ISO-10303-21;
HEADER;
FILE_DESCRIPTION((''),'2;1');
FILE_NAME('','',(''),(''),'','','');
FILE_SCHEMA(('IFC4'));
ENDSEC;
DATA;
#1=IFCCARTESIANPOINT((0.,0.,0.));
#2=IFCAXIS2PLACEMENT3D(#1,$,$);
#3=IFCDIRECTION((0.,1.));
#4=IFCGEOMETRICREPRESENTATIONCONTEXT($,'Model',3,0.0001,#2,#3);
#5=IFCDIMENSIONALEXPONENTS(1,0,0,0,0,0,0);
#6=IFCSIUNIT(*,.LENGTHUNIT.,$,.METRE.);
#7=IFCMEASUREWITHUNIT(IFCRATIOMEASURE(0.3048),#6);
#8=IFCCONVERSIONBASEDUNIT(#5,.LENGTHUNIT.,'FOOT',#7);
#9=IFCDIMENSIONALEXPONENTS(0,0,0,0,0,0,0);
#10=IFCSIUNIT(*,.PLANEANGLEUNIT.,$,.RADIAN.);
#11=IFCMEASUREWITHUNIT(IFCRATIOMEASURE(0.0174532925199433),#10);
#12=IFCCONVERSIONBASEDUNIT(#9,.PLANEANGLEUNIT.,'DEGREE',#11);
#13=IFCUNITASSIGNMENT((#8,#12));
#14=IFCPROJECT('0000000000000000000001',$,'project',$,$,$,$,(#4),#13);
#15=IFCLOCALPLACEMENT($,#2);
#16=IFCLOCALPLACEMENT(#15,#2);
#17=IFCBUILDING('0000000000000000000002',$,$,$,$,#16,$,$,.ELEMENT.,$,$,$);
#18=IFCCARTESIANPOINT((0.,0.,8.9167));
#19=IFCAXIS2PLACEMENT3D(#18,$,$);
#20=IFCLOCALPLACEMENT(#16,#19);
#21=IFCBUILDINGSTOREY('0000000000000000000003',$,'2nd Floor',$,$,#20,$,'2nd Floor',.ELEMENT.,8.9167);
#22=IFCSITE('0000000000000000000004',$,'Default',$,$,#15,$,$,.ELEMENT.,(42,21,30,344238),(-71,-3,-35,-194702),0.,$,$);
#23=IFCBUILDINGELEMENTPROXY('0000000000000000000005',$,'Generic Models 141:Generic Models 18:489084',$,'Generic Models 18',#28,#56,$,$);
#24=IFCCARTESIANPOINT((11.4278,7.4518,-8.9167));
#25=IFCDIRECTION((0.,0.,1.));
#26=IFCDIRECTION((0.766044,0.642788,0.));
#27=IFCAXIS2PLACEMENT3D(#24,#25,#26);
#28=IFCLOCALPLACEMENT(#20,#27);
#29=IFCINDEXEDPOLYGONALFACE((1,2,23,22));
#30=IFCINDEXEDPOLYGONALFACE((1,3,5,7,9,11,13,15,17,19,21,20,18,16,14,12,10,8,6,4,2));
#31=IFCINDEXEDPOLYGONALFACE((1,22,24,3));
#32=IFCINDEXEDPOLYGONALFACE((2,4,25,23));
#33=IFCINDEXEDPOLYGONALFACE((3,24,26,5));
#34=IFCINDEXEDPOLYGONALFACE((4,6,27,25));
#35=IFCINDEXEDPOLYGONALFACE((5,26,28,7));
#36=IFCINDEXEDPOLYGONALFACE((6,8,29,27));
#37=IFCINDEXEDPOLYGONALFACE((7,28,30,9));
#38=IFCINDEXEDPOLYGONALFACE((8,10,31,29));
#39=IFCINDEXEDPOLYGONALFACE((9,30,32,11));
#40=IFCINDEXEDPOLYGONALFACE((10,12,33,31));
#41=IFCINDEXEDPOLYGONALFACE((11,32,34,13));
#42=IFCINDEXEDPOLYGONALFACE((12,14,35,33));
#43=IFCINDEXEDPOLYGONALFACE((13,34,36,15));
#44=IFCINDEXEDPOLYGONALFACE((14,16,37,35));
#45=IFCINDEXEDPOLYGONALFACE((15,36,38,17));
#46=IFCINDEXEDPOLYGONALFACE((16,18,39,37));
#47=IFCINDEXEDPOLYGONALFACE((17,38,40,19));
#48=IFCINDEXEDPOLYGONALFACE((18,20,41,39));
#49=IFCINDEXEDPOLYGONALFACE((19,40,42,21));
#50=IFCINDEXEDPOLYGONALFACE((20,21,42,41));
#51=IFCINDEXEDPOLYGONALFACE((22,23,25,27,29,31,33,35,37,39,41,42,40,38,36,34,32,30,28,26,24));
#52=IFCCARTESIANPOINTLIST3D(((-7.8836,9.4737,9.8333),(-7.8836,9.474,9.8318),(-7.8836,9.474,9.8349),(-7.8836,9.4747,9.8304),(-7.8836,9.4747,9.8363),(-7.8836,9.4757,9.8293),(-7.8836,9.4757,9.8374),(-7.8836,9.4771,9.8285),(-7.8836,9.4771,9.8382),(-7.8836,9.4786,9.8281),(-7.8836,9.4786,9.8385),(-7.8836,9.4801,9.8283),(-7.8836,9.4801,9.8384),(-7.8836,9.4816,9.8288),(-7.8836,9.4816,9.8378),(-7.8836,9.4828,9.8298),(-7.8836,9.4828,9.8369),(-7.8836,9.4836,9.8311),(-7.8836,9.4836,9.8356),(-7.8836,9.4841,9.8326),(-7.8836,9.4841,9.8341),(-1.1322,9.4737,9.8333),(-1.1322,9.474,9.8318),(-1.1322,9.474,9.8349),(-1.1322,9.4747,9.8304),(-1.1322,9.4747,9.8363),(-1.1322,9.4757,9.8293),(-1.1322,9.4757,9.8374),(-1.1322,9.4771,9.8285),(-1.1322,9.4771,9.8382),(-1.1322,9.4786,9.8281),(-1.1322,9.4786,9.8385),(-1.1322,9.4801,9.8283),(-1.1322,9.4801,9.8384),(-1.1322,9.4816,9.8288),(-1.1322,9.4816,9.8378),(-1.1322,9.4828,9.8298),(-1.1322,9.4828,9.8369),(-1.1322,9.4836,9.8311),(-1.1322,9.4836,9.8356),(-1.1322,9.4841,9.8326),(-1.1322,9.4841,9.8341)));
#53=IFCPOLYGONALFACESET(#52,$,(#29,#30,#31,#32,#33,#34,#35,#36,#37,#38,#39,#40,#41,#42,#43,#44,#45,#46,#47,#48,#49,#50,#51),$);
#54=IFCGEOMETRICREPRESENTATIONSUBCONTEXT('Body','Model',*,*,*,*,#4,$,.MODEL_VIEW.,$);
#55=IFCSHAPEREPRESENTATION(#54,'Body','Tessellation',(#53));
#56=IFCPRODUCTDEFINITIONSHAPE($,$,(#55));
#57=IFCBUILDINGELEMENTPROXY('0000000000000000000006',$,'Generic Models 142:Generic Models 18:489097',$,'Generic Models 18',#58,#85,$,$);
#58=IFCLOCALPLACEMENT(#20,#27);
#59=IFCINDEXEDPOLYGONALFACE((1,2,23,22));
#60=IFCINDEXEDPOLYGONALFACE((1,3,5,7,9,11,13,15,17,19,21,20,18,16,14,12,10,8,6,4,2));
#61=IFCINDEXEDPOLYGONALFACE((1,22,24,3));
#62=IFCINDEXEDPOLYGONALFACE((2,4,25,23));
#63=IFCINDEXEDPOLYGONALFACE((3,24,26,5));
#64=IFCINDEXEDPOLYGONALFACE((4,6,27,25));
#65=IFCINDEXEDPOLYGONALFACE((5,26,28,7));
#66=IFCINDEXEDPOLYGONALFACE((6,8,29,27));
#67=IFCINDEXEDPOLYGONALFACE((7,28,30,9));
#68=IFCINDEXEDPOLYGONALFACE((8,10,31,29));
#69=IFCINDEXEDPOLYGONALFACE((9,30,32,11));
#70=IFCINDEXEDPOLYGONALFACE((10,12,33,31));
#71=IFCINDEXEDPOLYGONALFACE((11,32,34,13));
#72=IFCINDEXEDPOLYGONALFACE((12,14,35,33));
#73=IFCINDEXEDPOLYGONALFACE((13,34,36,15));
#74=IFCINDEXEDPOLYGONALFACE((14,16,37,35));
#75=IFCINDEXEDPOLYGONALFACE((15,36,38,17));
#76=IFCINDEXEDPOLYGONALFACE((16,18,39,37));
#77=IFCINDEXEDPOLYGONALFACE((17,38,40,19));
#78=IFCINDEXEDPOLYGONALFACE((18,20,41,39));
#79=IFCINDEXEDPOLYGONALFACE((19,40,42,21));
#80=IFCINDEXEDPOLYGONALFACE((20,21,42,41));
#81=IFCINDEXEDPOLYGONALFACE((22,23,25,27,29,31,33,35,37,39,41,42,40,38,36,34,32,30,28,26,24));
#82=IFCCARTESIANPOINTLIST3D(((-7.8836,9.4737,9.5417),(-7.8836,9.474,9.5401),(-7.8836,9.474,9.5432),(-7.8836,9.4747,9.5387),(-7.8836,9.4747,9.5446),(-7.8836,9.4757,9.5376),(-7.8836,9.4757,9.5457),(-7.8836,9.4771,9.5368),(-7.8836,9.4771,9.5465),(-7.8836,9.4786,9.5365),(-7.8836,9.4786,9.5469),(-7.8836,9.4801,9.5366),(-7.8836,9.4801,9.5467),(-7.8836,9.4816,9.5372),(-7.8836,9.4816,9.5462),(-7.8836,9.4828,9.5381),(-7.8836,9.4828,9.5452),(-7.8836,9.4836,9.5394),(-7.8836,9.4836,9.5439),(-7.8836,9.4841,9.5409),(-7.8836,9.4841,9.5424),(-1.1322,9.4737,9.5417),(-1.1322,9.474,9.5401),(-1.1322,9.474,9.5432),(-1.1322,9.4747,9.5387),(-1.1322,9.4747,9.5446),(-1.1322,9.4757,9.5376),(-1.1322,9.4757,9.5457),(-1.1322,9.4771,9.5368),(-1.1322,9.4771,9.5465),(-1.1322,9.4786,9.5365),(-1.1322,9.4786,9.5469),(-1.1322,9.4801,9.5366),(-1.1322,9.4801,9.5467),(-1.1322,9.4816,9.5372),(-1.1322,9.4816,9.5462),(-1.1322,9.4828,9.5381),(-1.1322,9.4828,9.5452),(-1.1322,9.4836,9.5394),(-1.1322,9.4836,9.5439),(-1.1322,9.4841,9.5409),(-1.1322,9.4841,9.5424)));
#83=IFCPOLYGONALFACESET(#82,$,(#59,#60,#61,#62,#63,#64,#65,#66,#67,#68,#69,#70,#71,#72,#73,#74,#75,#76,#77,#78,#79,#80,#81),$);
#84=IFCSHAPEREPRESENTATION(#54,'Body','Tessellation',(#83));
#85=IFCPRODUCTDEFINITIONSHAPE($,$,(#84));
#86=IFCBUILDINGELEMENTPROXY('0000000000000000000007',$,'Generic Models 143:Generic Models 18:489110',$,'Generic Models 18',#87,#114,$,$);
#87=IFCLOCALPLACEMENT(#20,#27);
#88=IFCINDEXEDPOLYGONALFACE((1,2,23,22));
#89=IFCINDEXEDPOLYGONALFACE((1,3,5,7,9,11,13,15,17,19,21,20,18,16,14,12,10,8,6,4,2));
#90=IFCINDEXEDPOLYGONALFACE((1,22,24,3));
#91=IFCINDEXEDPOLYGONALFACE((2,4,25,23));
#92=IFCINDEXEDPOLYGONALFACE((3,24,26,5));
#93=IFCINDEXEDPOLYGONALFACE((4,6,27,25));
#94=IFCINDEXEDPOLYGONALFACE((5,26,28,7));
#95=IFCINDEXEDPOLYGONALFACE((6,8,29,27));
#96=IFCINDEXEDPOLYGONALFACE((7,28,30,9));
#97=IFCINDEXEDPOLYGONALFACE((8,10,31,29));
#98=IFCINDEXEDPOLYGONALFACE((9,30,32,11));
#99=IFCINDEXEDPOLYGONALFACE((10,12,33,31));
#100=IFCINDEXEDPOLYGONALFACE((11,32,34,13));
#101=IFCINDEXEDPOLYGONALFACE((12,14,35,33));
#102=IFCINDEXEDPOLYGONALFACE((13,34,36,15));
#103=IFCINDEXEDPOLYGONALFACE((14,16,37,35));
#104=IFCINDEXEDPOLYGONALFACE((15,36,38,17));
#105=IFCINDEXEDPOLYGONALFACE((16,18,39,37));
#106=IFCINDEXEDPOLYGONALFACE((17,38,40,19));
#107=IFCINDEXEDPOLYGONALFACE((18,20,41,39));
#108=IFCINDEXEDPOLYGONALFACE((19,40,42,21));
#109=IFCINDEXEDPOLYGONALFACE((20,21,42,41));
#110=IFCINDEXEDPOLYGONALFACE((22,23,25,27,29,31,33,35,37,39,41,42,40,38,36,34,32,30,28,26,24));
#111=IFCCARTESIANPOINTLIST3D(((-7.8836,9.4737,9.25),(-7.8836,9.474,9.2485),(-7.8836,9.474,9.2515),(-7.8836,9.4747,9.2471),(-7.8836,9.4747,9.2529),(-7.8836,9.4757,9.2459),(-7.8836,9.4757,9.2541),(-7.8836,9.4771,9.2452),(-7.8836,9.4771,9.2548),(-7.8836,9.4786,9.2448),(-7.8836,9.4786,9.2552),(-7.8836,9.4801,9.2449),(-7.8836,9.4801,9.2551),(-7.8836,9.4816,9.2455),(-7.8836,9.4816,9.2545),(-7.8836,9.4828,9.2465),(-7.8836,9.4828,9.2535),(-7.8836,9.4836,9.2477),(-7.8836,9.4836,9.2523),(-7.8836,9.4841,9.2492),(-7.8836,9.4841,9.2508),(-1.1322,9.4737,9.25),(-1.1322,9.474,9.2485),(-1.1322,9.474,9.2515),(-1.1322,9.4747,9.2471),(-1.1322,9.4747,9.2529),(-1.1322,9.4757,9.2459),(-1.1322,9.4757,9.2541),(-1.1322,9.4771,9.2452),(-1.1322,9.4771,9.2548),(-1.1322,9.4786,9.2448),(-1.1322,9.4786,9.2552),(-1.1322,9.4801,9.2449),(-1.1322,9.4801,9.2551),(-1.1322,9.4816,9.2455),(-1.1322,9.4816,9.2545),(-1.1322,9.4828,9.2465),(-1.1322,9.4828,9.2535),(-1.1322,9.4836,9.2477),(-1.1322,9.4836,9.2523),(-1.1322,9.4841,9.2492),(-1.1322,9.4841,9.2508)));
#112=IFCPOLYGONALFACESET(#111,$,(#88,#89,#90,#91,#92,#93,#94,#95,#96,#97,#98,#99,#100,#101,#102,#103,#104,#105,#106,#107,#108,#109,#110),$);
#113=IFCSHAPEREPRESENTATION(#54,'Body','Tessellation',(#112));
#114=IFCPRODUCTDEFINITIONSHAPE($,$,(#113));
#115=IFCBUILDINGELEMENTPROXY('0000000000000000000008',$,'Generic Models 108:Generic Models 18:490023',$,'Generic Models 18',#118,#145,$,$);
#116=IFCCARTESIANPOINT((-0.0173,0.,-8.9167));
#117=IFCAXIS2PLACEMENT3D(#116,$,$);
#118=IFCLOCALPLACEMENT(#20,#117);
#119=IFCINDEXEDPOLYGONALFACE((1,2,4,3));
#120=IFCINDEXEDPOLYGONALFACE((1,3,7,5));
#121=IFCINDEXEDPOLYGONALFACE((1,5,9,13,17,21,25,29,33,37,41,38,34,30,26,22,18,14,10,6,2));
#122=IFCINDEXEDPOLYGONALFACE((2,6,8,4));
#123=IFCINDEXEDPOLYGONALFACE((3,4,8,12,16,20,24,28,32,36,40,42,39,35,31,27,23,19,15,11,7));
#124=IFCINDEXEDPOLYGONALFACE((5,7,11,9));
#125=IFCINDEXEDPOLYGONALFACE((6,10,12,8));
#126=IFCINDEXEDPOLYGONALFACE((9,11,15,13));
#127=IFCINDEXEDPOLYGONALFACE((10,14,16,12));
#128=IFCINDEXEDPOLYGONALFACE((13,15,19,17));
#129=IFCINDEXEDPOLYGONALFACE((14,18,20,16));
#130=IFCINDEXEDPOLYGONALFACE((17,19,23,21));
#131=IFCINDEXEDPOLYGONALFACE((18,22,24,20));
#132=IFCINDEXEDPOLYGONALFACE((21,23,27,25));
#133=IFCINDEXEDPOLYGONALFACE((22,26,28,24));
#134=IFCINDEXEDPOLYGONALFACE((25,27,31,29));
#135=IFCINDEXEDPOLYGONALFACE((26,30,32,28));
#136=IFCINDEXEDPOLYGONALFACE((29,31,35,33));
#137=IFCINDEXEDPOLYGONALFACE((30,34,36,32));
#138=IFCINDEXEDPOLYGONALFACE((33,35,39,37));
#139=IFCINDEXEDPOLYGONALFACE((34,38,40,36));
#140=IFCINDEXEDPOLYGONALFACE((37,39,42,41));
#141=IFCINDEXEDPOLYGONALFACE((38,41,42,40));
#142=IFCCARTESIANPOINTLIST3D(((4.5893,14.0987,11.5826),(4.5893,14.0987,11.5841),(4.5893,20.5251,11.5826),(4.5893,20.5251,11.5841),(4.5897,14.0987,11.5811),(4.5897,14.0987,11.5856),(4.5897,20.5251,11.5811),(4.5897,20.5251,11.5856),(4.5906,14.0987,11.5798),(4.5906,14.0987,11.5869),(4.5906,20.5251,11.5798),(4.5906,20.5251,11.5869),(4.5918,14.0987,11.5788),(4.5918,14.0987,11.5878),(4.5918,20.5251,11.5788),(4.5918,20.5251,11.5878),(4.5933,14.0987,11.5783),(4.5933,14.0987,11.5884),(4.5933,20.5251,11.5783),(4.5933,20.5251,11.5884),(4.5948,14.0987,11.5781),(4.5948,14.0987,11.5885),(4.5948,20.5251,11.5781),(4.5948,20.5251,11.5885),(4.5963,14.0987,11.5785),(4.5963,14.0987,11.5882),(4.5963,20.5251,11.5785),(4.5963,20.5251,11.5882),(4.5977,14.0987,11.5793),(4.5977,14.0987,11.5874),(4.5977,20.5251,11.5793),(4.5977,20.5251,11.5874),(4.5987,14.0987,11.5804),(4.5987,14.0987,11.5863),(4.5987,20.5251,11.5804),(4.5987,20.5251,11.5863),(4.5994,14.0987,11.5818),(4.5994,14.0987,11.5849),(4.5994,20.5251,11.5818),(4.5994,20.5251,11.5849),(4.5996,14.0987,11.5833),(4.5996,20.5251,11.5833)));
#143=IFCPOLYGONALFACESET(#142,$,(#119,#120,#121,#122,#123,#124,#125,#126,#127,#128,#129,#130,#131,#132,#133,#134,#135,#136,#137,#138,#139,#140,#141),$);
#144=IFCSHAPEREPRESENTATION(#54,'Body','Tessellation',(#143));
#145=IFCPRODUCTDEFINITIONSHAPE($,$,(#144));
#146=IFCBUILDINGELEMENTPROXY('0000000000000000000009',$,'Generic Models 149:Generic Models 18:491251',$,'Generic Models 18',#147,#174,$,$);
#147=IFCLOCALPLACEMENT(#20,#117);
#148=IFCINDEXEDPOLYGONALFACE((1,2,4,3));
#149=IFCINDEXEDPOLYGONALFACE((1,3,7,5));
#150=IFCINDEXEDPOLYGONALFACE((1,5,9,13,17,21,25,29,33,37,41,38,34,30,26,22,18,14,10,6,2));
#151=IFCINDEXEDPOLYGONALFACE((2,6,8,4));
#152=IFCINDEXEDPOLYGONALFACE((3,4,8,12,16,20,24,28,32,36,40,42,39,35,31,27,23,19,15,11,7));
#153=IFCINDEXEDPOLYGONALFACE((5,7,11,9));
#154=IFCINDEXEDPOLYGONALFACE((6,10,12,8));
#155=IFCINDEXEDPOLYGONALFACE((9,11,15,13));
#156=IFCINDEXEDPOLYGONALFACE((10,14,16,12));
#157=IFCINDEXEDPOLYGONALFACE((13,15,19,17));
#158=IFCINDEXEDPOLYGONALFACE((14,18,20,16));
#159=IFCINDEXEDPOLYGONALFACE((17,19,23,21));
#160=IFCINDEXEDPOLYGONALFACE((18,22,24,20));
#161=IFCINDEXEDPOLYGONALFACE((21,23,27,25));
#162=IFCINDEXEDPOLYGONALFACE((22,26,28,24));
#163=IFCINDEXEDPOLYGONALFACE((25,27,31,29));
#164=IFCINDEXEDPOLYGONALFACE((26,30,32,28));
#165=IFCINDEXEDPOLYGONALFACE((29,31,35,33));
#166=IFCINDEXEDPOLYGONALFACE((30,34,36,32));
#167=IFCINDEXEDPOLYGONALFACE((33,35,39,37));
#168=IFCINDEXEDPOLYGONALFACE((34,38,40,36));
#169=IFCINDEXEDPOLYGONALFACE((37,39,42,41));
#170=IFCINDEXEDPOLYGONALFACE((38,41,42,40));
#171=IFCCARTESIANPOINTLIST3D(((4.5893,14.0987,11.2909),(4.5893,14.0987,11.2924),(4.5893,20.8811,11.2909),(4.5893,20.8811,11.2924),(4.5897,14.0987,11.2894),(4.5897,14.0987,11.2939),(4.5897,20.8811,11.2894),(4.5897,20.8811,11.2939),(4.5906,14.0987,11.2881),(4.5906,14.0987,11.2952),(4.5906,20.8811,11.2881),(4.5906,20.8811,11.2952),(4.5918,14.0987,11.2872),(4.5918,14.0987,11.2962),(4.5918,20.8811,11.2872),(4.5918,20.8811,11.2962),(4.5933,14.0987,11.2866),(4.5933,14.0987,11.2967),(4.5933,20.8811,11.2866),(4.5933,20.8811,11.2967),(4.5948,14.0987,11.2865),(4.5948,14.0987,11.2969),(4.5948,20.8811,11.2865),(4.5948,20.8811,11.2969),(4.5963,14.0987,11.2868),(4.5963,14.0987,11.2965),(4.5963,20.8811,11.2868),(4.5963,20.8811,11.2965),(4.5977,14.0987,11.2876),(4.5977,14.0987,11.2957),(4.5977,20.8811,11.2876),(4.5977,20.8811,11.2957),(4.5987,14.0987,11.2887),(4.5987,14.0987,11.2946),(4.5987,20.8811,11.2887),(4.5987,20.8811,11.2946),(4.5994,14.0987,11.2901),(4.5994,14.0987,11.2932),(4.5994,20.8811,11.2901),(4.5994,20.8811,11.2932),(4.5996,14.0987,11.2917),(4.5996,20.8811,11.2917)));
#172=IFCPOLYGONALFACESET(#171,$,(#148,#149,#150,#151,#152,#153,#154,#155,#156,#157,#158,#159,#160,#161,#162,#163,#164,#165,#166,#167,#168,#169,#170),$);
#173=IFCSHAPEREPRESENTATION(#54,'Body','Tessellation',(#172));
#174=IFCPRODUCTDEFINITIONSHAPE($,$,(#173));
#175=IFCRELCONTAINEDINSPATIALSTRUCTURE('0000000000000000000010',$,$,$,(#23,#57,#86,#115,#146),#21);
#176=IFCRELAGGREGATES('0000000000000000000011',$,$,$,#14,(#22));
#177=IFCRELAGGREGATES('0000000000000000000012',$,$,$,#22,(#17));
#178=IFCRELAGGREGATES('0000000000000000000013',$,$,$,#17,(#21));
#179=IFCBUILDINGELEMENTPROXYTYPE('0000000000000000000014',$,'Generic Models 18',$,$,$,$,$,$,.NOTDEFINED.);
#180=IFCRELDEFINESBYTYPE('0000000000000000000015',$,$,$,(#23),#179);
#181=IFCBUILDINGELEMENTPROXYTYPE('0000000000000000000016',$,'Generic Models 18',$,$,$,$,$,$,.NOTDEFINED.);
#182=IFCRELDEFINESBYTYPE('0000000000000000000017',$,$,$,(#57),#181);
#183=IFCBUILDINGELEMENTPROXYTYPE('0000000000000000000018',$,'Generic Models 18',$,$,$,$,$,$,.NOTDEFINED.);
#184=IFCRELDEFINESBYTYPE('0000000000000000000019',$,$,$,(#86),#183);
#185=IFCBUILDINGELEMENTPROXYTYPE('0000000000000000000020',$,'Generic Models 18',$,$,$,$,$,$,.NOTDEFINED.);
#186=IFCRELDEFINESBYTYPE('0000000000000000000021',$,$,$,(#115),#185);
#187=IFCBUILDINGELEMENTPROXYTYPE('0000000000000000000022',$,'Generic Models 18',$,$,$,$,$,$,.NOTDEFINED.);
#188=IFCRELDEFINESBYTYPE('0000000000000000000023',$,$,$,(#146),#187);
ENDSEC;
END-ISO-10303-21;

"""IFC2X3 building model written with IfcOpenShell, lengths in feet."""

from ifc_helpers import new_model, entity, si_unit, converted_unit, direction, frame, origin, origin_2d_with_axis, place, context, subcontext, project, spatial, circle, extrude, source, transform, mapped, type_object, type_shapes, element, save


model = new_model("IFC2X3")

# Units and contexts
model_context = context("Model", 3, precision=0.0001, world=origin(), true_north=direction((0.0, 1.0)))
body_context = subcontext(model_context, "Body", "Model", "MODEL_VIEW")
ifc_project = project(units=[converted_unit("LENGTHUNIT", "FOOT", entity("IfcRatioMeasure", 0.3048), si_unit("LENGTHUNIT", "METRE"), dimensions=[1, 0, 0, 0, 0, 0, 0]), converted_unit("PLANEANGLEUNIT", "DEGREE", entity("IfcRatioMeasure", 0.0174532925199433), si_unit("PLANEANGLEUNIT", "RADIAN"), dimensions=[0, 0, 0, 0, 0, 0, 0])], contexts=[model_context])

# Site, building, storey
site_placement = place(None, origin())
site = spatial("IfcSite", under=ifc_project, at=site_placement, Name="Default", CompositionType="ELEMENT", RefLatitude=(42, 21, 30, 344238), RefLongitude=(-71, -3, -35, -194702), RefElevation=0.0)
building_placement = place(site_placement, origin())
building = spatial("IfcBuilding", under=site, at=building_placement, CompositionType="ELEMENT")
storey_placement = place(building_placement, frame((0.0, 0.0, 8.9167)))
storey = spatial("IfcBuildingStorey", under=building, at=storey_placement, Name="2nd Floor", LongName="2nd Floor", CompositionType="ELEMENT", Elevation=8.9167)

# Building element proxies
building_element_proxy_type_1 = type_object("IfcBuildingElementProxyType", Name="Generic Models 18", PredefinedType="NOTDEFINED")
shared_shape_1 = source(origin(), body_context, "Body", "SweptSolid", [
    extrude(circle(Radius=0.0052, at=origin_2d_with_axis()), frame((-7.8836, 9.479, 9.8333), z_axis=(1.0, 0.0, 0.0), x_axis=(0.0, -1.0, 0.0)), (0.0, 0.0, 1.0), 6.7514),
])
type_shapes(building_element_proxy_type_1, [shared_shape_1])
proxy_1_placement = place(storey_placement, frame((11.4278, 7.4518, -8.9167), z_axis=(0.0, 0.0, 1.0), x_axis=(0.766044, 0.642788, 0.0)))
element("IfcBuildingElementProxy", 1, at=proxy_1_placement, inside=storey, type_object=building_element_proxy_type_1, Name="Generic Models 141:Generic Models 18:489084", ObjectType="Generic Models 18", context=body_context, shape_type="MappedRepresentation", body=[
    mapped(shared_shape_1, transform((0.0, 0.0, 0.0), scale=1.0)),
])
building_element_proxy_type_2 = type_object("IfcBuildingElementProxyType", Name="Generic Models 18", PredefinedType="NOTDEFINED")
shared_shape_2 = source(origin(), body_context, "Body", "SweptSolid", [
    extrude(circle(Radius=0.0052, at=origin_2d_with_axis()), frame((-7.8836, 9.479, 9.5417), z_axis=(1.0, 0.0, 0.0), x_axis=(0.0, -1.0, 0.0)), (0.0, 0.0, 1.0), 6.7514),
])
type_shapes(building_element_proxy_type_2, [shared_shape_2])
proxy_2_placement = place(storey_placement, frame((11.4278, 7.4518, -8.9167), z_axis=(0.0, 0.0, 1.0), x_axis=(0.766044, 0.642788, 0.0)))
element("IfcBuildingElementProxy", 2, at=proxy_2_placement, inside=storey, type_object=building_element_proxy_type_2, Name="Generic Models 142:Generic Models 18:489097", ObjectType="Generic Models 18", context=body_context, shape_type="MappedRepresentation", body=[
    mapped(shared_shape_2, transform((0.0, 0.0, 0.0), scale=1.0)),
])
building_element_proxy_type_3 = type_object("IfcBuildingElementProxyType", Name="Generic Models 18", PredefinedType="NOTDEFINED")
shared_shape_3 = source(origin(), body_context, "Body", "SweptSolid", [
    extrude(circle(Radius=0.0052, at=origin_2d_with_axis()), frame((-7.8836, 9.479, 9.25), z_axis=(1.0, 0.0, 0.0), x_axis=(0.0, -1.0, 0.0)), (0.0, 0.0, 1.0), 6.7514),
])
type_shapes(building_element_proxy_type_3, [shared_shape_3])
proxy_3_placement = place(storey_placement, frame((11.4278, 7.4518, -8.9167), z_axis=(0.0, 0.0, 1.0), x_axis=(0.766044, 0.642788, 0.0)))
element("IfcBuildingElementProxy", 3, at=proxy_3_placement, inside=storey, type_object=building_element_proxy_type_3, Name="Generic Models 143:Generic Models 18:489110", ObjectType="Generic Models 18", context=body_context, shape_type="MappedRepresentation", body=[
    mapped(shared_shape_3, transform((0.0, 0.0, 0.0), scale=1.0)),
])
building_element_proxy_type_4 = type_object("IfcBuildingElementProxyType", Name="Generic Models 18", PredefinedType="NOTDEFINED")
shared_shape_4 = source(origin(), body_context, "Body", "SweptSolid", [
    extrude(circle(Radius=0.0052, at=origin_2d_with_axis()), frame((4.5944, 14.0987, 11.5833), z_axis=(0.0, 1.0, 0.0), x_axis=(1.0, 0.0, 0.0)), (0.0, 0.0, 1.0), 6.4264),
])
type_shapes(building_element_proxy_type_4, [shared_shape_4])
proxy_4_placement = place(storey_placement, frame((-0.0173, 0.0, -8.9167)))
element("IfcBuildingElementProxy", 4, at=proxy_4_placement, inside=storey, type_object=building_element_proxy_type_4, Name="Generic Models 108:Generic Models 18:490023", ObjectType="Generic Models 18", context=body_context, shape_type="MappedRepresentation", body=[
    mapped(shared_shape_4, transform((0.0, 0.0, 0.0), scale=1.0)),
])
building_element_proxy_type_5 = type_object("IfcBuildingElementProxyType", Name="Generic Models 18", PredefinedType="NOTDEFINED")
shared_shape_5 = source(origin(), body_context, "Body", "SweptSolid", [
    extrude(circle(Radius=0.0052, at=origin_2d_with_axis()), frame((4.5944, 14.0987, 11.2917), z_axis=(0.0, 1.0, 0.0), x_axis=(1.0, 0.0, 0.0)), (0.0, 0.0, 1.0), 6.7824),
])
type_shapes(building_element_proxy_type_5, [shared_shape_5])
proxy_5_placement = place(storey_placement, frame((-0.0173, 0.0, -8.9167)))
element("IfcBuildingElementProxy", 5, at=proxy_5_placement, inside=storey, type_object=building_element_proxy_type_5, Name="Generic Models 149:Generic Models 18:491251", ObjectType="Generic Models 18", context=body_context, shape_type="MappedRepresentation", body=[
    mapped(shared_shape_5, transform((0.0, 0.0, 0.0), scale=1.0)),
])

save(model, "model.ifc")
